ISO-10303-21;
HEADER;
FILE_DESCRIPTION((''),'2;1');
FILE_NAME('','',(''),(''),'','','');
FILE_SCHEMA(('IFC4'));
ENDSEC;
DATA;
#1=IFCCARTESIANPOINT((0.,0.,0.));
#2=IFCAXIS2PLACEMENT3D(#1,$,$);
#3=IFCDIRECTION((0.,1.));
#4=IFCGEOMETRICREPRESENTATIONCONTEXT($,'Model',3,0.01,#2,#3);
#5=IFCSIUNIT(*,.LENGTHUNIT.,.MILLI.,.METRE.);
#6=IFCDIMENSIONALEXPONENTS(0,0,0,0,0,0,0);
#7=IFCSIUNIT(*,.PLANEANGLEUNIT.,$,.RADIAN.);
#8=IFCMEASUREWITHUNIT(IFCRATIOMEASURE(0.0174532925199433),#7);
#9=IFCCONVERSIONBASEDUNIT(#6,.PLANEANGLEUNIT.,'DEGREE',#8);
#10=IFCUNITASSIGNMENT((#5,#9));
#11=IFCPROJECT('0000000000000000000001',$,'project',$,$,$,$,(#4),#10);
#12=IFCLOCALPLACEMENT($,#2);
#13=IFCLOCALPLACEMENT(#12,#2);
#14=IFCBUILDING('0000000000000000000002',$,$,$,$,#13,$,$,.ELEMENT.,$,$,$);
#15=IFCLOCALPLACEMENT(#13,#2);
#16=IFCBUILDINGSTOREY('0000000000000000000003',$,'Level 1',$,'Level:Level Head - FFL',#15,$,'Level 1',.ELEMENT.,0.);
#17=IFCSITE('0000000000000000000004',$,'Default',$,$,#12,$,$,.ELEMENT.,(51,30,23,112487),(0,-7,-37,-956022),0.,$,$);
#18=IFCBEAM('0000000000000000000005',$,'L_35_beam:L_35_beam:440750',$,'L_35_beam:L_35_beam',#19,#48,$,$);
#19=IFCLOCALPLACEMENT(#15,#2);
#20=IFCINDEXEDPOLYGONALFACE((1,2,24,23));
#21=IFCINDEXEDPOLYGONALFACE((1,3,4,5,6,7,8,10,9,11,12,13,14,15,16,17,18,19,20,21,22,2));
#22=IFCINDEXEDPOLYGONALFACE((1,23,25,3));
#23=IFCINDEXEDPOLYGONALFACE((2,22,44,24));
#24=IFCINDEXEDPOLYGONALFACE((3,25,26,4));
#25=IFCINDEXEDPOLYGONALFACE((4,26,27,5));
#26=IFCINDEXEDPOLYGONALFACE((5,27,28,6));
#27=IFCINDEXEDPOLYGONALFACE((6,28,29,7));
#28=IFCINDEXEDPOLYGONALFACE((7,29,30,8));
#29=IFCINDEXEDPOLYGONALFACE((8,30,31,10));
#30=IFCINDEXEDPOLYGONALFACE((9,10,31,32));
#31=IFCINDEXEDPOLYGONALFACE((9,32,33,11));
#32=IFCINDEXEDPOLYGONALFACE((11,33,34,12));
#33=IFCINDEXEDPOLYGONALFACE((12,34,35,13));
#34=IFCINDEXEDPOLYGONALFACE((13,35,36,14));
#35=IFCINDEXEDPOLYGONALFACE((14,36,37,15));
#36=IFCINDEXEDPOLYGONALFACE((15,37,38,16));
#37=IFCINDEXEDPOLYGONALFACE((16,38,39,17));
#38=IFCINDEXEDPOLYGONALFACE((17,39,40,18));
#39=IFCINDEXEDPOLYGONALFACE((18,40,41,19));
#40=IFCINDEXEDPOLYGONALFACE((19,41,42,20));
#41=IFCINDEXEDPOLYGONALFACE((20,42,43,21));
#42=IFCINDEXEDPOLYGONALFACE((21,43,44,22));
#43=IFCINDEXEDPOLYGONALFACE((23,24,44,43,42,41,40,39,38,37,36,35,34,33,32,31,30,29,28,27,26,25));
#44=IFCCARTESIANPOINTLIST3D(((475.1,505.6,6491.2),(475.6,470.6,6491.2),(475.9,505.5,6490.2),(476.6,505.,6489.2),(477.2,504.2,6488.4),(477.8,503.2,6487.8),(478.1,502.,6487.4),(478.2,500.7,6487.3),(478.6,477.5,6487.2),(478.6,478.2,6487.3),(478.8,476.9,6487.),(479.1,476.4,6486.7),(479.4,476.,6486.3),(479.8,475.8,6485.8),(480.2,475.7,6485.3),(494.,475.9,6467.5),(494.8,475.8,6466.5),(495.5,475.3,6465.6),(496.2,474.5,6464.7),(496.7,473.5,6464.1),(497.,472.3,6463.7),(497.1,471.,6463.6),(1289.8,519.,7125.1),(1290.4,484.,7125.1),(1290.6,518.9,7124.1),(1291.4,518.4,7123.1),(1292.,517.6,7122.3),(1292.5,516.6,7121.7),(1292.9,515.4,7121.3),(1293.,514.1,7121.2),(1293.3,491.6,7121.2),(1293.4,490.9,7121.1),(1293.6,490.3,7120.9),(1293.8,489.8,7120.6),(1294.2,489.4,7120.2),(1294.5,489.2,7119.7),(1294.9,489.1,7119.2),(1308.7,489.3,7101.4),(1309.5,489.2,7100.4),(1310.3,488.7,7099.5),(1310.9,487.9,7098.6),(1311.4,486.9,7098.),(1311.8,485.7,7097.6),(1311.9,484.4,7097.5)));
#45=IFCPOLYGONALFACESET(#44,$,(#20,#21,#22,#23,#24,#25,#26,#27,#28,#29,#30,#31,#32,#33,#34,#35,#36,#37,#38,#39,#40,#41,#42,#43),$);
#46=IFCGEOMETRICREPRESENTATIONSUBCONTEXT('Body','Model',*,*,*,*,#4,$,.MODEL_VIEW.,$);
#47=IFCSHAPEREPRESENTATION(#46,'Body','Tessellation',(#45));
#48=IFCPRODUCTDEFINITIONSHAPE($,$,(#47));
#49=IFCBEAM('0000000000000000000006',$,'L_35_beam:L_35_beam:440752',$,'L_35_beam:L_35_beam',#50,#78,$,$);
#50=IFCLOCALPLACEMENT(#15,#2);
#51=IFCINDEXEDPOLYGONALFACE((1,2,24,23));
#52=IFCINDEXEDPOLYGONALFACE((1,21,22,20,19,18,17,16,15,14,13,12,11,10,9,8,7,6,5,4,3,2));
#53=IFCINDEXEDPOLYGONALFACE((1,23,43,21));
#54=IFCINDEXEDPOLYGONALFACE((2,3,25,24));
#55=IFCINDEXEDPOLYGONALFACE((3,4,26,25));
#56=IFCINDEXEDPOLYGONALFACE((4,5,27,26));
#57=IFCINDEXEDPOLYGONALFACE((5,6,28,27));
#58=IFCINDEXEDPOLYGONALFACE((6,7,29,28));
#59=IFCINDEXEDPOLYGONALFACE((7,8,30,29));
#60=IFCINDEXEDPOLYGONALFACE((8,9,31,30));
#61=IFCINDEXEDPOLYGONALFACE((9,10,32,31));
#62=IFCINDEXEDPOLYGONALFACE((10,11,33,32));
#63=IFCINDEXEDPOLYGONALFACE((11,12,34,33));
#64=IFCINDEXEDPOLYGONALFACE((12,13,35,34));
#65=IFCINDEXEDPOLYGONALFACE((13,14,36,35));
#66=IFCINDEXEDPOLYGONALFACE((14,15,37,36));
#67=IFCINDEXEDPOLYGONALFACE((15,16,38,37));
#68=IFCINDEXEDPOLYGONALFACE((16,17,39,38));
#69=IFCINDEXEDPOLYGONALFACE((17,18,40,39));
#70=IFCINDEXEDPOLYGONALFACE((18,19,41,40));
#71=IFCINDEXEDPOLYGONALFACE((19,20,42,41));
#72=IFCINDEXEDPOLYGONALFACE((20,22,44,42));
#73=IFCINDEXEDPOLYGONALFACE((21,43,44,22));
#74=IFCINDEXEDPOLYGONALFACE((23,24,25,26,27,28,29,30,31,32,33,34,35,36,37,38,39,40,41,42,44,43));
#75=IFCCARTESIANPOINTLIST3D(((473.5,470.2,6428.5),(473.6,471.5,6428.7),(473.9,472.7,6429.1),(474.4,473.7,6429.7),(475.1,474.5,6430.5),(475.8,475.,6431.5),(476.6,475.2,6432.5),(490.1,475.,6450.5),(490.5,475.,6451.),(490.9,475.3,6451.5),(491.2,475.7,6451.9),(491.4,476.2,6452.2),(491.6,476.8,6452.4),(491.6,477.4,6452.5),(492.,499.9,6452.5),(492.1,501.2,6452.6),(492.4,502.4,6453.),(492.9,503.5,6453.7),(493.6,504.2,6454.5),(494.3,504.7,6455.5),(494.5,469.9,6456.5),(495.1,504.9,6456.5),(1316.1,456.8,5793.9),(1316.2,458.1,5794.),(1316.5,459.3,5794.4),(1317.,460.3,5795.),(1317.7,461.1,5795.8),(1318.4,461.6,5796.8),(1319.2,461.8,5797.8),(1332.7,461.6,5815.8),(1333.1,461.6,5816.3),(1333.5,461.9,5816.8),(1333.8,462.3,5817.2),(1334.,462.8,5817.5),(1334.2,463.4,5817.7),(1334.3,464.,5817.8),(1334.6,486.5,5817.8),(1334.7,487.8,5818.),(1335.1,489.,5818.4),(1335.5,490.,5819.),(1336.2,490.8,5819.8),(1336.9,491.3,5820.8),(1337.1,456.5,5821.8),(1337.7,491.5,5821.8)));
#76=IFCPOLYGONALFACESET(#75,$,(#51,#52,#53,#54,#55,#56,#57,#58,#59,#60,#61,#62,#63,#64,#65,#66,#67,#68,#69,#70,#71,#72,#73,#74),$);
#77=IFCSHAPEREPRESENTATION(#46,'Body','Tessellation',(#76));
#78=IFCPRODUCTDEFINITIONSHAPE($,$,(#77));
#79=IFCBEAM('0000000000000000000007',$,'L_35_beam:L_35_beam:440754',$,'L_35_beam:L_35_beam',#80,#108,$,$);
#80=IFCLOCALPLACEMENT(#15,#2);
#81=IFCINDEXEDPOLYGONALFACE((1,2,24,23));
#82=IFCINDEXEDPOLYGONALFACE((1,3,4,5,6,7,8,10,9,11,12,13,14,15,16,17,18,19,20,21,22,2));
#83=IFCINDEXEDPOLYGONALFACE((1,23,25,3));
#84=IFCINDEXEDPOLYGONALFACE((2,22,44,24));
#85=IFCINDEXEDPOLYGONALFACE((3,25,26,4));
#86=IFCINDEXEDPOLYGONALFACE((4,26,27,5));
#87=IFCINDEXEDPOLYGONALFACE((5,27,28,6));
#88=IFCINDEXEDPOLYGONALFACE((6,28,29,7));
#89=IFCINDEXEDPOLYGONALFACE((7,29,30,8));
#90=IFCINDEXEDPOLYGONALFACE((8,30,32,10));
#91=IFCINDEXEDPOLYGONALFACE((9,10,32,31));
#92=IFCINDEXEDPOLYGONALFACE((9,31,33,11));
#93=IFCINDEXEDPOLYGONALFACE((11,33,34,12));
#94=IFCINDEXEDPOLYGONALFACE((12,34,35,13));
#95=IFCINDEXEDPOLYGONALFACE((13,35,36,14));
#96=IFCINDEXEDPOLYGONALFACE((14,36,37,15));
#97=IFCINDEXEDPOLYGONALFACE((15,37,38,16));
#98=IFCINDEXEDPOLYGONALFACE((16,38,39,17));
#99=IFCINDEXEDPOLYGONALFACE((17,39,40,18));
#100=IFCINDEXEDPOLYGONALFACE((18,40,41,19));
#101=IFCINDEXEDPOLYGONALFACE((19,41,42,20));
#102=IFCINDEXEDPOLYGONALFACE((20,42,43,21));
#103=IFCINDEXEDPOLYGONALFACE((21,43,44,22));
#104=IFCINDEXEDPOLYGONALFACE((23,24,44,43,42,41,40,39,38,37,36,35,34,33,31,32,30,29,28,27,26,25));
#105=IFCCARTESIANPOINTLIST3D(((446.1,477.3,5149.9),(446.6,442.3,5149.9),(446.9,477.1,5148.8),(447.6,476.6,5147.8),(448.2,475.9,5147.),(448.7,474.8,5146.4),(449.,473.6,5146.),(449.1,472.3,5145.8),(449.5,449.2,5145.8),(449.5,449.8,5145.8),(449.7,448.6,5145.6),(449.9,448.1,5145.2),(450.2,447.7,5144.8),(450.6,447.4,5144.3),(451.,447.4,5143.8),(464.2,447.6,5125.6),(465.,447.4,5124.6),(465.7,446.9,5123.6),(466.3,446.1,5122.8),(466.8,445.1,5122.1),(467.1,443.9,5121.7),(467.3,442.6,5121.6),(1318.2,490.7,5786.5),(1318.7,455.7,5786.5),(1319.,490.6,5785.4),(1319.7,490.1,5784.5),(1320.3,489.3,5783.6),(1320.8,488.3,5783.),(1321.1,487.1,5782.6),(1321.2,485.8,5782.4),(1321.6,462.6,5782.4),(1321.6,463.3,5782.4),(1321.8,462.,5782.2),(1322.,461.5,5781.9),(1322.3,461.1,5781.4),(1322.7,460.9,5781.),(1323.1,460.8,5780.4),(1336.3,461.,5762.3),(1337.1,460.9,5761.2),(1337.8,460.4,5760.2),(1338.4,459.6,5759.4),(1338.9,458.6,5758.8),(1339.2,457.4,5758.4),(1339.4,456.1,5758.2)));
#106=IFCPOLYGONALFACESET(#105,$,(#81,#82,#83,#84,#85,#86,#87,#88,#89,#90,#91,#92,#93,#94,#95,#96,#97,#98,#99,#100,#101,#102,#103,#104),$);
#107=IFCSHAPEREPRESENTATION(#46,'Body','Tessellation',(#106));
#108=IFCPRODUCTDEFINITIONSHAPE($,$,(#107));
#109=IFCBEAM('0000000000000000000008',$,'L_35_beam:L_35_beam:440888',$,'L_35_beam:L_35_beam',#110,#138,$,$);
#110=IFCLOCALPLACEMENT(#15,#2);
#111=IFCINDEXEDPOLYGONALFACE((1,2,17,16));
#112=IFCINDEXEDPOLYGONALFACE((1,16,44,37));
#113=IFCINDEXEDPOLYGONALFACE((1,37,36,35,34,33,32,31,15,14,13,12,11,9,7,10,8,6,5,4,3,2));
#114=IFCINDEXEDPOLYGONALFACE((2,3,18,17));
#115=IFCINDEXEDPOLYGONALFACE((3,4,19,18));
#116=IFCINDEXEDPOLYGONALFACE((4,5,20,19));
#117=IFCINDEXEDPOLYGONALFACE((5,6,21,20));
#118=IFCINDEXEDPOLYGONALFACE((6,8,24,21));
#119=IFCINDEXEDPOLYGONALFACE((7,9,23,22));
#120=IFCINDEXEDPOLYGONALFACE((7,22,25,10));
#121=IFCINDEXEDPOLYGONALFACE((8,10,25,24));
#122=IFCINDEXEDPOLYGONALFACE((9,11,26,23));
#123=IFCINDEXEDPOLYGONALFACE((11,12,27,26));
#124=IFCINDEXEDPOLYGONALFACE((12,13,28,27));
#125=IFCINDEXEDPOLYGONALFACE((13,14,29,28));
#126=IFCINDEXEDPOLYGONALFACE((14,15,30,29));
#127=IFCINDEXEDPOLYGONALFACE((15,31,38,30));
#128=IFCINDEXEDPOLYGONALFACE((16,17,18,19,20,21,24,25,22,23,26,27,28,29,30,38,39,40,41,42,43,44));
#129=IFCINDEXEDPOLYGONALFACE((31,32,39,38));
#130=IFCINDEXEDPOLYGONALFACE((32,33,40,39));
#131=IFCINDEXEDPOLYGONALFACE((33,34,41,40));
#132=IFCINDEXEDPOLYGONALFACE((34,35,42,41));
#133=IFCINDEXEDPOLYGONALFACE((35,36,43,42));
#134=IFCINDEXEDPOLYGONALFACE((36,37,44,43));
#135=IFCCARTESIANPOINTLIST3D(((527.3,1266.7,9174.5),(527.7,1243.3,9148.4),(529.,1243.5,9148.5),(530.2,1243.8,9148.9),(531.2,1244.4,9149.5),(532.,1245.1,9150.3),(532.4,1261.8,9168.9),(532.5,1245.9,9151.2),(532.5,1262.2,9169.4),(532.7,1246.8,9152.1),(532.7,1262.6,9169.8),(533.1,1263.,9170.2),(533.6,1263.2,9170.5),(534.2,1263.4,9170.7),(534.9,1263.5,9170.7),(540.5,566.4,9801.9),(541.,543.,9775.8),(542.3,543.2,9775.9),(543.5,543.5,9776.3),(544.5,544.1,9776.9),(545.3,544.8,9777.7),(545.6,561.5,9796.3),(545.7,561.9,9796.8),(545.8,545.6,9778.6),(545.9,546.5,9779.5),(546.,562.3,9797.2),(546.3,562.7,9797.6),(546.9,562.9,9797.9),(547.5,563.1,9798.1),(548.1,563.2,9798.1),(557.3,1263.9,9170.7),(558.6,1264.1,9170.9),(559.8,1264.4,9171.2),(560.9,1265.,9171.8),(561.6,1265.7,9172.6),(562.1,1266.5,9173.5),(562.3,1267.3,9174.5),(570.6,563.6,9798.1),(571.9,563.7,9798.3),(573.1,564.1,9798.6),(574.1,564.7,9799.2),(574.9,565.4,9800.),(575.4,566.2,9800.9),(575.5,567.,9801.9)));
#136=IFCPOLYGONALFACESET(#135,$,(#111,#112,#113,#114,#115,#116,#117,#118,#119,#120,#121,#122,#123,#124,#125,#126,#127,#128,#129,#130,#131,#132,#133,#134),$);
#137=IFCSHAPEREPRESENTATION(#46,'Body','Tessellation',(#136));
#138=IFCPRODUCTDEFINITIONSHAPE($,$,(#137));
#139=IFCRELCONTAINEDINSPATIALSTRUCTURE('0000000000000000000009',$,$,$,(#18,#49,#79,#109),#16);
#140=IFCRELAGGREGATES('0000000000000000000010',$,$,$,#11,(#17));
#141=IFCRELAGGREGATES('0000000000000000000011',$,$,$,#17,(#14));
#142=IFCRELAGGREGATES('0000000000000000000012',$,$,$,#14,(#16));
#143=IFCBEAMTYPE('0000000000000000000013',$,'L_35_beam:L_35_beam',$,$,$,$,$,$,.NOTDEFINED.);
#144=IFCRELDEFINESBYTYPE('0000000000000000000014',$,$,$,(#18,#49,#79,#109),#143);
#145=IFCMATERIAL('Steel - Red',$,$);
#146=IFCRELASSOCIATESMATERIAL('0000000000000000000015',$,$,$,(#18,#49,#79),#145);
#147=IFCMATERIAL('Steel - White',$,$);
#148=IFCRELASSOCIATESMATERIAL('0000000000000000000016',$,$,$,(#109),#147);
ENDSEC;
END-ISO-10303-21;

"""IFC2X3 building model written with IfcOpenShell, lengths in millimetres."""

from ifc_helpers import new_model, entity, si_unit, converted_unit, direction, frame, frame_2d, origin, place, context, subcontext, project, spatial, polyline, circle_curve, parameter, trimmed, segment, composite_curve, outline, extrude, material, type_object, element, save


model = new_model("IFC2X3")

# Units and contexts
model_context = context("Model", 3, precision=0.01, world=origin(), true_north=direction((0.0, 1.0)))
body_context = subcontext(model_context, "Body", "Model", "MODEL_VIEW")
ifc_project = project(units=[si_unit("LENGTHUNIT", "METRE", prefix="MILLI"), converted_unit("PLANEANGLEUNIT", "DEGREE", entity("IfcRatioMeasure", 0.0174532925199433), si_unit("PLANEANGLEUNIT", "RADIAN"), dimensions=[0, 0, 0, 0, 0, 0, 0])], contexts=[model_context])

# Site, building, storey
site_placement = place(None, origin())
site = spatial("IfcSite", under=ifc_project, at=site_placement, Name="Default", CompositionType="ELEMENT", RefLatitude=(51, 30, 23, 112487), RefLongitude=(0, -7, -37, -956022), RefElevation=0.0)
building_placement = place(site_placement, origin())
building = spatial("IfcBuilding", under=site, at=building_placement, CompositionType="ELEMENT")
storey_placement = place(building_placement, origin())
storey = spatial("IfcBuildingStorey", under=building, at=storey_placement, Name="Level 1", ObjectType="Level:Level Head - FFL", LongName="Level 1", CompositionType="ELEMENT", Elevation=0.0)

# Beams
ifc_material_1 = material(Name="Steel - Red")
ifc_material_2 = material(Name="Steel - White")
beam_type_1 = type_object("IfcBeamType", Name="L_35_beam:L_35_beam", PredefinedType="NOTDEFINED")
beam_1_placement = place(storey_placement, frame((1323.4, 476.6, 7128.5), z_axis=(-0.61392, -0.010092, 0.789304), x_axis=(-0.789197, -0.012974, -0.614003)))
element("IfcBeam", 1, at=beam_1_placement, inside=storey, type_object=beam_type_1, material=ifc_material_1, Name="L_35_beam:L_35_beam:440750", ObjectType="L_35_beam:L_35_beam", context=body_context, shape_type="SweptSolid", body=[
    extrude(outline(composite_curve([segment(polyline([(-23.2, -11.8), (11.8, -11.8)]), True, "CONTINUOUS"), segment(polyline([(11.8, -11.8), (11.8, 23.2)]), True, "CONTINUOUS"), segment(trimmed(circle_curve(frame_2d((11.8, 18.2), x_axis=(0.0, 1.0)), 5.0), [parameter(0.0)], [parameter(90.0)], True, "PARAMETER"), True, "CONTINUOUS"), segment(polyline([(6.8, 18.2), (6.8, -4.3)]), True, "CONTINUOUS"), segment(trimmed(circle_curve(frame_2d((4.3, -4.3), x_axis=(1.0, 0.0)), 2.5), [parameter(270.0)], [parameter(0.0)], True, "PARAMETER"), False, "CONTINUOUS"), segment(polyline([(4.3, -6.8), (-18.2, -6.8)]), True, "CONTINUOUS"), segment(trimmed(circle_curve(frame_2d((-18.2, -11.8), x_axis=(0.0, 1.0)), 5.0), [parameter(0.0)], [parameter(90.0)], True, "PARAMETER"), True, "CONTINUOUS")], self_intersect=False)), frame((28.0, -19.8, 5.7), z_axis=(1.0, 0.0, 0.0), x_axis=(0.0, 0.0, 1.0)), (0.0, 0.0, 1.0), 1032.4),
])
beam_2_placement = place(storey_placement, frame((1351.7, 448.2, 5788.8), z_axis=(0.60153, -0.009574, 0.798793), x_axis=(-0.798692, 0.012712, 0.601606)))
element("IfcBeam", 2, at=beam_2_placement, inside=storey, type_object=beam_type_1, material=ifc_material_1, Name="L_35_beam:L_35_beam:440752", ObjectType="L_35_beam:L_35_beam", context=body_context, shape_type="SweptSolid", body=[
    extrude(outline(composite_curve([segment(polyline([(-23.2, -11.8), (11.8, -11.8)]), True, "CONTINUOUS"), segment(polyline([(11.8, -11.8), (11.8, 23.2)]), True, "CONTINUOUS"), segment(trimmed(circle_curve(frame_2d((11.8, 18.2), x_axis=(0.0, 1.0)), 5.0), [parameter(0.0)], [parameter(90.0)], True, "PARAMETER"), True, "CONTINUOUS"), segment(polyline([(6.8, 18.2), (6.8, -4.3)]), True, "CONTINUOUS"), segment(trimmed(circle_curve(frame_2d((4.3, -4.3), x_axis=(1.0, 0.0)), 2.5), [parameter(270.0)], [parameter(0.0)], True, "PARAMETER"), False, "CONTINUOUS"), segment(polyline([(4.3, -6.8), (-18.2, -6.8)]), True, "CONTINUOUS"), segment(trimmed(circle_curve(frame_2d((-18.2, -11.8), x_axis=(0.0, 1.0)), 5.0), [parameter(0.0)], [parameter(90.0)], True, "PARAMETER"), True, "CONTINUOUS")], self_intersect=False)), frame((31.6, -19.8, 5.7), z_axis=(1.0, 0.0, 0.0), x_axis=(0.0, 0.0, 1.0)), (0.0, 0.0, 1.0), 1055.0),
])
beam_3_placement = place(storey_placement, frame((1351.7, 448.2, 5788.8), z_axis=(-0.589494, -0.009093, 0.807721), x_axis=(-0.807625, -0.012457, -0.589564)))
element("IfcBeam", 3, at=beam_3_placement, inside=storey, type_object=beam_type_1, material=ifc_material_1, Name="L_35_beam:L_35_beam:440754", ObjectType="L_35_beam:L_35_beam", context=body_context, shape_type="SweptSolid", body=[
    extrude(outline(composite_curve([segment(polyline([(-23.2, -11.8), (11.8, -11.8)]), True, "CONTINUOUS"), segment(polyline([(11.8, -11.8), (11.8, 23.2)]), True, "CONTINUOUS"), segment(trimmed(circle_curve(frame_2d((11.8, 18.2), x_axis=(0.0, 1.0)), 5.0), [parameter(0.0)], [parameter(90.0)], True, "PARAMETER"), True, "CONTINUOUS"), segment(polyline([(6.8, 18.2), (6.8, -4.3)]), True, "CONTINUOUS"), segment(trimmed(circle_curve(frame_2d((4.3, -4.3), x_axis=(1.0, 0.0)), 2.5), [parameter(270.0)], [parameter(0.0)], True, "PARAMETER"), False, "CONTINUOUS"), segment(polyline([(4.3, -6.8), (-18.2, -6.8)]), True, "CONTINUOUS"), segment(trimmed(circle_curve(frame_2d((-18.2, -11.8), x_axis=(0.0, 1.0)), 5.0), [parameter(0.0)], [parameter(90.0)], True, "PARAMETER"), True, "CONTINUOUS")], self_intersect=False)), frame((27.9, -19.8, 5.7), z_axis=(1.0, 0.0, 0.0), x_axis=(0.0, 0.0, 1.0)), (0.0, 0.0, 1.0), 1079.8),
])
beam_4_placement = place(storey_placement, frame((533.2, 533.2, 9807.9), z_axis=(-0.012627, 0.667081, 0.744878), x_axis=(-0.014097, 0.744745, -0.6672)))
element("IfcBeam", 4, at=beam_4_placement, inside=storey, type_object=beam_type_1, material=ifc_material_2, Name="L_35_beam:L_35_beam:440888", ObjectType="L_35_beam:L_35_beam", context=body_context, shape_type="SweptSolid", body=[
    extrude(outline(composite_curve([segment(polyline([(-23.2, -11.8), (11.8, -11.8)]), True, "CONTINUOUS"), segment(polyline([(11.8, -11.8), (11.8, 23.2)]), True, "CONTINUOUS"), segment(trimmed(circle_curve(frame_2d((11.8, 18.2), x_axis=(0.0, 1.0)), 5.0), [parameter(0.0)], [parameter(90.0)], True, "PARAMETER"), True, "CONTINUOUS"), segment(polyline([(6.8, 18.2), (6.8, -4.3)]), True, "CONTINUOUS"), segment(trimmed(circle_curve(frame_2d((4.3, -4.3), x_axis=(1.0, 0.0)), 2.5), [parameter(270.0)], [parameter(0.0)], True, "PARAMETER"), False, "CONTINUOUS"), segment(polyline([(4.3, -6.8), (-18.2, -6.8)]), True, "CONTINUOUS"), segment(trimmed(circle_curve(frame_2d((-18.2, -11.8), x_axis=(0.0, 1.0)), 5.0), [parameter(0.0)], [parameter(90.0)], True, "PARAMETER"), True, "CONTINUOUS")], self_intersect=False)), frame((28.6, -19.8, 5.7), z_axis=(1.0, 0.0, 0.0), x_axis=(0.0, 0.0, 1.0)), (0.0, 0.0, 1.0), 940.3),
])

save(model, "model.ifc")
